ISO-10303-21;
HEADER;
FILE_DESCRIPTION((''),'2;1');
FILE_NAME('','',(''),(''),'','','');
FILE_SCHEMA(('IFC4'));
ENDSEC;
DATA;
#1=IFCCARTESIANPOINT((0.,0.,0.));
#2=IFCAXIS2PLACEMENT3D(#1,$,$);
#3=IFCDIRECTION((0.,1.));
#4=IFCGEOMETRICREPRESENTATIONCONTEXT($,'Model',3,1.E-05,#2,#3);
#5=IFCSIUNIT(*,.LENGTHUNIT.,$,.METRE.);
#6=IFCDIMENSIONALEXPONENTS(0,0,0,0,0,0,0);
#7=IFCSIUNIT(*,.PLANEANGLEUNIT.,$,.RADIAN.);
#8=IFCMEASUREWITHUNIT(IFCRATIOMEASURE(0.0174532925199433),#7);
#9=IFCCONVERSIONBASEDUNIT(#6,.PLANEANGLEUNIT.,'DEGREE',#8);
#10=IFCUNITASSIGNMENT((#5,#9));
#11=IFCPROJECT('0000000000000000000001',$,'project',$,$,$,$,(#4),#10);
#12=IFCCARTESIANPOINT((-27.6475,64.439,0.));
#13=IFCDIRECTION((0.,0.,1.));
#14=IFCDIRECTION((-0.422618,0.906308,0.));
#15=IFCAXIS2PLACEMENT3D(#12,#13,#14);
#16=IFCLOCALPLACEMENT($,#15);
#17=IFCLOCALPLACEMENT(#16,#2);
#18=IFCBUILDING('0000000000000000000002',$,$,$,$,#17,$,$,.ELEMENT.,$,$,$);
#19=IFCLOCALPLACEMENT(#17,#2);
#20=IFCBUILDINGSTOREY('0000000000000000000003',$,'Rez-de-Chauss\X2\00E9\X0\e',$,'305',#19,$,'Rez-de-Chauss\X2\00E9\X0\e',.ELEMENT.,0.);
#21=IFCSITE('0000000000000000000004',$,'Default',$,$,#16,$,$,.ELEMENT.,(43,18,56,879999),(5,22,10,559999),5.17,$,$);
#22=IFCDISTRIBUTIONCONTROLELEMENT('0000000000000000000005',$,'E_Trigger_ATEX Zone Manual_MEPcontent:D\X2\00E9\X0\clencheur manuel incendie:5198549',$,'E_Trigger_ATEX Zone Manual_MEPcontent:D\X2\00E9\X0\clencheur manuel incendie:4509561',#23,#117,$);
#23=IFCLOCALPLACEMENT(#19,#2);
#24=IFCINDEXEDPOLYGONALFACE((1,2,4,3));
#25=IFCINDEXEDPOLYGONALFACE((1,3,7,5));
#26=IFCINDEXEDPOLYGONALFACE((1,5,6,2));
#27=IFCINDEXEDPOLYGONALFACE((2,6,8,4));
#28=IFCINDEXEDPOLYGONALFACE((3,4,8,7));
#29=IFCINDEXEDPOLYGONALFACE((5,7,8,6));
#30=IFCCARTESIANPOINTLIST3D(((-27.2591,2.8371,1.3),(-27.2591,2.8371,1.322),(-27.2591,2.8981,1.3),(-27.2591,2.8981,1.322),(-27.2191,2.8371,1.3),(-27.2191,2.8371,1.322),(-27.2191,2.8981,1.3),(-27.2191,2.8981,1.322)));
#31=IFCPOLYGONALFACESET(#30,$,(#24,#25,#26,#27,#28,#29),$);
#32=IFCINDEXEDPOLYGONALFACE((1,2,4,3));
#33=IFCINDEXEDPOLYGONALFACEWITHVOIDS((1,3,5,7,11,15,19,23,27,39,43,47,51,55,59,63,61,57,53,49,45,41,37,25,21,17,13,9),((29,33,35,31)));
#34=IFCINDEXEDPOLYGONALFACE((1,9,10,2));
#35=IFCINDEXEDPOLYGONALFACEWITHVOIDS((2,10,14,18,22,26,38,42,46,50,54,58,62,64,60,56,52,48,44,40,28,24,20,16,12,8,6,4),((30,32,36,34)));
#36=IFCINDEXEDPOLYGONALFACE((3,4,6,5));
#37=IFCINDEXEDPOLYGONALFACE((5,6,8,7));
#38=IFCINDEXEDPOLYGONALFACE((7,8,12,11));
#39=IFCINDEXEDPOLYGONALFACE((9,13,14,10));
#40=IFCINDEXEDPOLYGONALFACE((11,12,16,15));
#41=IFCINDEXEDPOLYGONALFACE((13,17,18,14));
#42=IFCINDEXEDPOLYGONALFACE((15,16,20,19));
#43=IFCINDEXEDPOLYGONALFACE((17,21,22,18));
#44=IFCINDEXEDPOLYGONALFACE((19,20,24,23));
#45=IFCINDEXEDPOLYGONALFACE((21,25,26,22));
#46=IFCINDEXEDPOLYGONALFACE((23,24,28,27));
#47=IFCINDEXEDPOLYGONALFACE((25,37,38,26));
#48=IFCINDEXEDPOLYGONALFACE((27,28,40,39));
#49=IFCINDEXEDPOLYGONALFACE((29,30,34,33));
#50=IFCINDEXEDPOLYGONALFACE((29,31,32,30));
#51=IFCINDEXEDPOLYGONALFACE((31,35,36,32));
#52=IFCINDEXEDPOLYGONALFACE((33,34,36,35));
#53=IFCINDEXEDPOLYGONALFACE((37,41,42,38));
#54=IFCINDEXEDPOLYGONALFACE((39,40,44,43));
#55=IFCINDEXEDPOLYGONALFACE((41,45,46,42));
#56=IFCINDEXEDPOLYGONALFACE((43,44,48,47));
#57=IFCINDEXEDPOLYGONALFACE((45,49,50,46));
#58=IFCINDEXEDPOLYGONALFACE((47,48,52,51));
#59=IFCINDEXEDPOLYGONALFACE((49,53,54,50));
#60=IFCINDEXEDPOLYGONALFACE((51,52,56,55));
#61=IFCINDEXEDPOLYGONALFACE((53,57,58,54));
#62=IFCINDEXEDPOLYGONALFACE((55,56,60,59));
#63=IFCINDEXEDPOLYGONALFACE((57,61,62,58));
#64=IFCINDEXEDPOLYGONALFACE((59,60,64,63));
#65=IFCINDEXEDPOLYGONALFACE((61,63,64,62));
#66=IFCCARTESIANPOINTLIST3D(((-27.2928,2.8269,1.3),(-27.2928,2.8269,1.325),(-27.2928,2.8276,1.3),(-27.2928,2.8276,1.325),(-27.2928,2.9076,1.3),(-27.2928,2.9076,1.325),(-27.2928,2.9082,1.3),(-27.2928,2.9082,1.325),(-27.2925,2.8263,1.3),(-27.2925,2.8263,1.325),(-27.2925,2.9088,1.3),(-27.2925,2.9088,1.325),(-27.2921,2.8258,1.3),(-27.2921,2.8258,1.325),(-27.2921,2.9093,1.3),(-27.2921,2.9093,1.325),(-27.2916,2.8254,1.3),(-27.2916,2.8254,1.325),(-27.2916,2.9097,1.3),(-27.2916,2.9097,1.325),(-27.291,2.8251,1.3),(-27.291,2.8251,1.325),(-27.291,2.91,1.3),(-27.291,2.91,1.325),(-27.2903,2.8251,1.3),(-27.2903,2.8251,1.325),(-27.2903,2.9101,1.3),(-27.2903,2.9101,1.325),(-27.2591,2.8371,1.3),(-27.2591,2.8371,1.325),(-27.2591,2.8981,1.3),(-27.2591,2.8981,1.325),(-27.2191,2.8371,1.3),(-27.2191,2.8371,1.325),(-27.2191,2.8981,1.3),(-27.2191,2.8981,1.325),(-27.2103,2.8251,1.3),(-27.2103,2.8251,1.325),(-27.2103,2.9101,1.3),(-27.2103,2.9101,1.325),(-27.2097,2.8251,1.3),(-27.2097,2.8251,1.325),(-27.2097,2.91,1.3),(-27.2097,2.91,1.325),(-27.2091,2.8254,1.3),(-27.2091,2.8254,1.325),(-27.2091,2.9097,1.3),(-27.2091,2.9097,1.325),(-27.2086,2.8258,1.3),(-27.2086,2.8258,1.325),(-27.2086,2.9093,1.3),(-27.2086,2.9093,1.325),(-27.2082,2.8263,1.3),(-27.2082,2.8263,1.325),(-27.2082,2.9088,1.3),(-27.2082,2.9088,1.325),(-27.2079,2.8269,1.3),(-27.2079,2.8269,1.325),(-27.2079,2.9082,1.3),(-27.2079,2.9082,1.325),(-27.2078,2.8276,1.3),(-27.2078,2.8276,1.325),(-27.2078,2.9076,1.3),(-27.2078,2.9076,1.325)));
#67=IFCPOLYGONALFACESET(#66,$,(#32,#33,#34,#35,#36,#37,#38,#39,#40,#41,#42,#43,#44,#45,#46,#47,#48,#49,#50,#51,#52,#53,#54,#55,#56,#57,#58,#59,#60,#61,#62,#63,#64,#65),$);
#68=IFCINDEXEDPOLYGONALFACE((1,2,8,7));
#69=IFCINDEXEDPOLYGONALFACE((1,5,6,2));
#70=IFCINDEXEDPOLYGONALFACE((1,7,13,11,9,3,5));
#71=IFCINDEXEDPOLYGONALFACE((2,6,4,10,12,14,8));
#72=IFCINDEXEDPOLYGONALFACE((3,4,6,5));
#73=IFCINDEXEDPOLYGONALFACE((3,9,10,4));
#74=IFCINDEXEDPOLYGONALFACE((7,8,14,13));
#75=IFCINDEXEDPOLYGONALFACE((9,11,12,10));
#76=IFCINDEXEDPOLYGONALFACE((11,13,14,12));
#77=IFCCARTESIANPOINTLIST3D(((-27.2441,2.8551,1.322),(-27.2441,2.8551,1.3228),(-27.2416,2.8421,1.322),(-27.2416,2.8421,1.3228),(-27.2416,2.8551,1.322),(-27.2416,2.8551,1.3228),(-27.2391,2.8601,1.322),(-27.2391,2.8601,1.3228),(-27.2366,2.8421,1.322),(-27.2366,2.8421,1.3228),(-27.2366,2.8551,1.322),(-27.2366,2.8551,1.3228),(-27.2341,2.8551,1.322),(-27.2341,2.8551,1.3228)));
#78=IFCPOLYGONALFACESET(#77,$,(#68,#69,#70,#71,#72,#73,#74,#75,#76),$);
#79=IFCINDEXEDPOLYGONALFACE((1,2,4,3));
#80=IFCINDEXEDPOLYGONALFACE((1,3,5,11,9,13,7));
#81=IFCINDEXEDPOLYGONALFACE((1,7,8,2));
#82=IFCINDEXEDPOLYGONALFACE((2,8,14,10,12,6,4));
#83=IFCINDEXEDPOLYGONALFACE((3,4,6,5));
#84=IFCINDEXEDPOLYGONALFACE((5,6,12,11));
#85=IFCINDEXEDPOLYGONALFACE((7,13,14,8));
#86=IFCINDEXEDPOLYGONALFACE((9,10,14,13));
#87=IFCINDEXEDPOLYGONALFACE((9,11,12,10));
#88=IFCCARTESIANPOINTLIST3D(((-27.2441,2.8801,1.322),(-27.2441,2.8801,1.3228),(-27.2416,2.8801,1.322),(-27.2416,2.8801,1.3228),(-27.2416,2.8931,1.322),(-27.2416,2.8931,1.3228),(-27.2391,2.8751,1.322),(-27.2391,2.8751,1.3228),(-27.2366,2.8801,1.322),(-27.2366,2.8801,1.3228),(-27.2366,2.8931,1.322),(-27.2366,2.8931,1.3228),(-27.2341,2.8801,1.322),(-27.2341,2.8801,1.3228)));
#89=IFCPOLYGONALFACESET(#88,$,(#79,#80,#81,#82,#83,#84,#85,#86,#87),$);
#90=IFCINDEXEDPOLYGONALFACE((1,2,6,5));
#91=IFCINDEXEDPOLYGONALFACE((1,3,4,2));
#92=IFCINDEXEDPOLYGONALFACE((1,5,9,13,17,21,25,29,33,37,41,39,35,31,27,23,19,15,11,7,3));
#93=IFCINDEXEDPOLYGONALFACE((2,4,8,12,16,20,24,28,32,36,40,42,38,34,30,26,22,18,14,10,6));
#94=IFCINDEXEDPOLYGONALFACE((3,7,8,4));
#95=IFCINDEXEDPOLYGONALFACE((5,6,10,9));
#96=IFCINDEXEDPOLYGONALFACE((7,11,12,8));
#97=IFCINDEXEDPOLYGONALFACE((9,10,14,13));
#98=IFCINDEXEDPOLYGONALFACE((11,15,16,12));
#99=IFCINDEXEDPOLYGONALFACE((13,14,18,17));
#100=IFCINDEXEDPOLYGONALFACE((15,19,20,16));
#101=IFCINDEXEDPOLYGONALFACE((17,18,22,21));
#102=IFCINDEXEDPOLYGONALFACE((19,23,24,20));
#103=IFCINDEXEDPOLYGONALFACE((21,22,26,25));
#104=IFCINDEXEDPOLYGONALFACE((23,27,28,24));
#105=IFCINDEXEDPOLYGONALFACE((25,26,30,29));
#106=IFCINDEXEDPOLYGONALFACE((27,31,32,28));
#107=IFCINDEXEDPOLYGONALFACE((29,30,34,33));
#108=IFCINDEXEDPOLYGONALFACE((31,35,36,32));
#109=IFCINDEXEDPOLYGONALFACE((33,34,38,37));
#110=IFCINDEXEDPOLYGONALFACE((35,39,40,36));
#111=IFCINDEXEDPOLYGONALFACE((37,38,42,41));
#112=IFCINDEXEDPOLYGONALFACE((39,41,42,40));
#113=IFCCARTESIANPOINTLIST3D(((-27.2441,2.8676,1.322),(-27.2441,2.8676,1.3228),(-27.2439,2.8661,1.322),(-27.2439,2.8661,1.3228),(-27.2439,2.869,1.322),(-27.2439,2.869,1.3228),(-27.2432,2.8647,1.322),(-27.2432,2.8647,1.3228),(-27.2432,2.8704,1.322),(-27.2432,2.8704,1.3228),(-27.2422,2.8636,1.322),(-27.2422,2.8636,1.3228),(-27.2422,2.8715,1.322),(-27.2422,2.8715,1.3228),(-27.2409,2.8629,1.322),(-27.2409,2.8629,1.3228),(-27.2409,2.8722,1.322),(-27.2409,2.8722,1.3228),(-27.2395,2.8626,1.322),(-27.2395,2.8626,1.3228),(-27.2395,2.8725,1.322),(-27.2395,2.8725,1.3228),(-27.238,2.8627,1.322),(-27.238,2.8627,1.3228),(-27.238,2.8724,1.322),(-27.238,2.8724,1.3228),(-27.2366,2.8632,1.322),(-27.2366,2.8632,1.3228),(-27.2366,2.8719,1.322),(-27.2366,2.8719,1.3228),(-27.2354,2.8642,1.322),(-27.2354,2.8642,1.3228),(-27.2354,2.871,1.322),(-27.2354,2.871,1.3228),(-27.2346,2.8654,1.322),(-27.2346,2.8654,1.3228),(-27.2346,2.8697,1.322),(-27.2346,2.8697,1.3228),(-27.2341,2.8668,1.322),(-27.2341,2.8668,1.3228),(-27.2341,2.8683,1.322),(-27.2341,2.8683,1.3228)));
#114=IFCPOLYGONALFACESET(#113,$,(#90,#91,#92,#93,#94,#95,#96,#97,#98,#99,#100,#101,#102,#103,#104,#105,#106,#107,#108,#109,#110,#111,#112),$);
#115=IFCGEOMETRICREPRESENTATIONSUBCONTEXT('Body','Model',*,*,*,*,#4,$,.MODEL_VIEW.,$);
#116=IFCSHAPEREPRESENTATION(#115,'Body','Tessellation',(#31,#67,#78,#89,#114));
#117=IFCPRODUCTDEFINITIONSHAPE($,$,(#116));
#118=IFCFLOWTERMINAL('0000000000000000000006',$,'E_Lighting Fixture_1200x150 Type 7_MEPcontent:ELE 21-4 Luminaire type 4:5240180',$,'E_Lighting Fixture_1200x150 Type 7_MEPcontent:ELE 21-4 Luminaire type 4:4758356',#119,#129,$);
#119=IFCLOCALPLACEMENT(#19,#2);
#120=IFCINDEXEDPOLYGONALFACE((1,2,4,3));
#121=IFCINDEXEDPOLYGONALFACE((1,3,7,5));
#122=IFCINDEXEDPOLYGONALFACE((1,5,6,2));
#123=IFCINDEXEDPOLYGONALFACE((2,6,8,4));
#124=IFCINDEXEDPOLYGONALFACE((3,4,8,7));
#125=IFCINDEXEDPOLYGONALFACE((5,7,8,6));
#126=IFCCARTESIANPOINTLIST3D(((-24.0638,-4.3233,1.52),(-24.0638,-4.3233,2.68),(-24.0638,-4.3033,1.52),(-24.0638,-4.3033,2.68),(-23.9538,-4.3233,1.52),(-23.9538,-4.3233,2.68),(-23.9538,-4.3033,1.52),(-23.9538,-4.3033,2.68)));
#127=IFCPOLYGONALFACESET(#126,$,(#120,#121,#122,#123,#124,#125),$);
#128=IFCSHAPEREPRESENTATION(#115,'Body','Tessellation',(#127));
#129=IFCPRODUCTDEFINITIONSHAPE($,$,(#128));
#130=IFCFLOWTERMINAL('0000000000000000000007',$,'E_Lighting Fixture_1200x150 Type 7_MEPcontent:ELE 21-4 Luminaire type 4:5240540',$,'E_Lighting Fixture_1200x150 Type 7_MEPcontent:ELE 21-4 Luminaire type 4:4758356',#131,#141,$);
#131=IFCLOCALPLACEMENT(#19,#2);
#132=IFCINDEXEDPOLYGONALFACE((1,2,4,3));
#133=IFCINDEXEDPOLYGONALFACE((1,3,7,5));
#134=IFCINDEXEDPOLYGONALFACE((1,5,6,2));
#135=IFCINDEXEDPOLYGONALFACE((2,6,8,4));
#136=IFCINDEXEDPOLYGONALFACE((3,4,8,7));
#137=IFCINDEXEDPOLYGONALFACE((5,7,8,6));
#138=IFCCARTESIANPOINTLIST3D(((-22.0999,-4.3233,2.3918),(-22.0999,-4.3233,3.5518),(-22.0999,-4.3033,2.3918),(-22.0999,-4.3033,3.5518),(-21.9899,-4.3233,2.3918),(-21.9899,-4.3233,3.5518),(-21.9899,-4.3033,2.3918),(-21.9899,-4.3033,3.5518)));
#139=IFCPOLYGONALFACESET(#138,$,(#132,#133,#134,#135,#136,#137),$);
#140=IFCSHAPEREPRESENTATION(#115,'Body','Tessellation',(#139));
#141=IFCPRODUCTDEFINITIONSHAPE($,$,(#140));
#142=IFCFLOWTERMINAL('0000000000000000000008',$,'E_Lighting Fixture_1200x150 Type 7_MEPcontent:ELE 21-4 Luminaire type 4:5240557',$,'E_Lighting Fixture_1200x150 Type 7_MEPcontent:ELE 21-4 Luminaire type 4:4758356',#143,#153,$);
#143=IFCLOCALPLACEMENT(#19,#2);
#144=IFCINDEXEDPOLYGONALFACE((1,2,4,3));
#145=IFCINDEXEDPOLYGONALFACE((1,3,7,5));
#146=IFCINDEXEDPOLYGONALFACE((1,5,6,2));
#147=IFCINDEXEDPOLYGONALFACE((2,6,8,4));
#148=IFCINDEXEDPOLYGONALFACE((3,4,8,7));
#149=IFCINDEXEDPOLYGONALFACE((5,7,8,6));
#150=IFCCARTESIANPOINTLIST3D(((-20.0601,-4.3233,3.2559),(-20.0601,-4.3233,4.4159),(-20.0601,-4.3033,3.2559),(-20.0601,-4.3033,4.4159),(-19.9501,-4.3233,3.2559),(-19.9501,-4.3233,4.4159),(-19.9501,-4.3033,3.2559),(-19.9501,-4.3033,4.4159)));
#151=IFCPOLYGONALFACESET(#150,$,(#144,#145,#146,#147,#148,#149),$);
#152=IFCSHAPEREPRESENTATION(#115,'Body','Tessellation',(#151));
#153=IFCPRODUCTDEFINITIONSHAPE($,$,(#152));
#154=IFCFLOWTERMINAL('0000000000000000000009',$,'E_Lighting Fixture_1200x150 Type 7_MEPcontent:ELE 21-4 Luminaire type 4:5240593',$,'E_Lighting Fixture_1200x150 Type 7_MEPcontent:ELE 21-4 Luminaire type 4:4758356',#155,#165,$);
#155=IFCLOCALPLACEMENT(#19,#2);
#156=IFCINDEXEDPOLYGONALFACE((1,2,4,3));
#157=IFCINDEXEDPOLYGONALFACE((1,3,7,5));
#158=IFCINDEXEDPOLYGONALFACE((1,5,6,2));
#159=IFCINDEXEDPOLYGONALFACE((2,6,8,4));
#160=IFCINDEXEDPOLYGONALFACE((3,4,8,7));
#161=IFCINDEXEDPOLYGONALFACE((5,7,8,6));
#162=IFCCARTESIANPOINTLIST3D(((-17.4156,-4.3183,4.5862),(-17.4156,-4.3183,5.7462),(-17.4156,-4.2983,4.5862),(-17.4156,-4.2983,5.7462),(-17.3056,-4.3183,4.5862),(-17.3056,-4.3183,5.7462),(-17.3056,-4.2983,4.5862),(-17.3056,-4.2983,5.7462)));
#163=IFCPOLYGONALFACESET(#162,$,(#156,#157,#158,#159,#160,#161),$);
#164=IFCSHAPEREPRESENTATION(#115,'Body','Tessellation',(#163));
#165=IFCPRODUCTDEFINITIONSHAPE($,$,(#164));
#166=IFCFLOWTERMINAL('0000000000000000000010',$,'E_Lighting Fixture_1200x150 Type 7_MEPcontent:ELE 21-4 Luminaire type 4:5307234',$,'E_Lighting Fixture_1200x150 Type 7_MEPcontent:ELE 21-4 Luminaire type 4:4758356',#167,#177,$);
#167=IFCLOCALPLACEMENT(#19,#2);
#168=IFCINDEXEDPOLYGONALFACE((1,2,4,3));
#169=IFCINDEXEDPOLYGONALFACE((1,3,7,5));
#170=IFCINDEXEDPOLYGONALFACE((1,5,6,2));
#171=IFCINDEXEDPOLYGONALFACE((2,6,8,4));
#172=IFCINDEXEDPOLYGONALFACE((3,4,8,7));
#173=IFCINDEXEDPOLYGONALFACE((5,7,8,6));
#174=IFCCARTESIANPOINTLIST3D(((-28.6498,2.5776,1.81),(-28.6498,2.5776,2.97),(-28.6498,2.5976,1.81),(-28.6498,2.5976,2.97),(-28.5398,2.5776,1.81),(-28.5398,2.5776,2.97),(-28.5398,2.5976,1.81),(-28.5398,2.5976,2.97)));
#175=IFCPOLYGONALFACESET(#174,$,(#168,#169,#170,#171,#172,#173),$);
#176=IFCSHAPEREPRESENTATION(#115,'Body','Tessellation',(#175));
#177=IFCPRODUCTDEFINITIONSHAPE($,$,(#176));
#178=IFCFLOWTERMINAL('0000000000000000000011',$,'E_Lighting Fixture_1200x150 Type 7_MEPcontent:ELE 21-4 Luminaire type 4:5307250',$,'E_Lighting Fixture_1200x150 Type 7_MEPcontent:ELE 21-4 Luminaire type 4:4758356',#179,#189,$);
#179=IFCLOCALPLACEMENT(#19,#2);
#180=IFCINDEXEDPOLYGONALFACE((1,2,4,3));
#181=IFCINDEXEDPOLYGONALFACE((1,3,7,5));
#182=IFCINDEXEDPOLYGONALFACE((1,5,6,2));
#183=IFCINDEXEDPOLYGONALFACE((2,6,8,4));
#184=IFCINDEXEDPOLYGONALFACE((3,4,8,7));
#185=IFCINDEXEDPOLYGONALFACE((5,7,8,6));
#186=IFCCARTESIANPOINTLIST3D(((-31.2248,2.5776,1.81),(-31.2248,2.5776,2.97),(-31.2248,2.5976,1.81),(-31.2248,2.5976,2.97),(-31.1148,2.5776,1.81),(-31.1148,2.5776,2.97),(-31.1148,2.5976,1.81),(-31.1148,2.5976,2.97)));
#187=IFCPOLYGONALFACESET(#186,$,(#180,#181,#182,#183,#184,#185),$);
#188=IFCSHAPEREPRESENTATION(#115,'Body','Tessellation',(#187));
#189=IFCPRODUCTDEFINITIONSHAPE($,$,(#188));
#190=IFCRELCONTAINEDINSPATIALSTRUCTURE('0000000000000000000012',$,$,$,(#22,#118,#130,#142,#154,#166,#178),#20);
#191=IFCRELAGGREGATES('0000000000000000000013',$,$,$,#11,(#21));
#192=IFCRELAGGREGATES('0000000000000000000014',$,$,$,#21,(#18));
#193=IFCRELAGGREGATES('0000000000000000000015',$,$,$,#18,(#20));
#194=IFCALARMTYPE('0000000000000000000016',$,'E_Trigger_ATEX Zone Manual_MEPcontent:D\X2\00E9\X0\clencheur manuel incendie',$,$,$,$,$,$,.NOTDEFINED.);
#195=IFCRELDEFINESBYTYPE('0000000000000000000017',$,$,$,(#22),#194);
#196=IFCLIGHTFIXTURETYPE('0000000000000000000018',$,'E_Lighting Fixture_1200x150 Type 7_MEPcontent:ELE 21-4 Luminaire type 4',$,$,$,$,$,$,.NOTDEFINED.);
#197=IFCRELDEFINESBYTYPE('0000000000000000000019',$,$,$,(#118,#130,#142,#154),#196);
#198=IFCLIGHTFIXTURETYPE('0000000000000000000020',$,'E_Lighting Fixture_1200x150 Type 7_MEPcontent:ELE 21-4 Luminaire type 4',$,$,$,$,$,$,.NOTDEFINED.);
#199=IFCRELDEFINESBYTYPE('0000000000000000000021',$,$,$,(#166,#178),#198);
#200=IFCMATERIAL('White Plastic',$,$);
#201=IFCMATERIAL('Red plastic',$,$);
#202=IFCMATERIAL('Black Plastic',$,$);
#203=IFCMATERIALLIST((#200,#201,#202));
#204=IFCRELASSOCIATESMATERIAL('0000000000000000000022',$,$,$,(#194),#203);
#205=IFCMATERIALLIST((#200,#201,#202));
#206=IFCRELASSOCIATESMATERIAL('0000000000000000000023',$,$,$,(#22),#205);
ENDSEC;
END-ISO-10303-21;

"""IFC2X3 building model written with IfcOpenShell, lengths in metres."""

from ifc_helpers import new_model, entity, si_unit, converted_unit, direction, frame, frame_2d, origin, origin_2d_with_axis, place, context, subcontext, project, spatial, polyline, circle_curve, parameter, trimmed, segment, composite_curve, rectangle, circle, outline, extrude, source, transform, mapped, material, material_list, type_object, type_shapes, element, save


model = new_model("IFC2X3")

# Units and contexts
model_context = context("Model", 3, precision=1e-05, world=origin(), true_north=direction((0.0, 1.0)))
body_context = subcontext(model_context, "Body", "Model", "MODEL_VIEW")
ifc_project = project(units=[si_unit("LENGTHUNIT", "METRE"), converted_unit("PLANEANGLEUNIT", "DEGREE", entity("IfcRatioMeasure", 0.0174532925199433), si_unit("PLANEANGLEUNIT", "RADIAN"), dimensions=[0, 0, 0, 0, 0, 0, 0])], contexts=[model_context])

# Site, building, storey
site_placement = place(None, frame((-27.6475, 64.439, 0.0), z_axis=(0.0, 0.0, 1.0), x_axis=(-0.422618, 0.906308, 0.0)))
site = spatial("IfcSite", under=ifc_project, at=site_placement, Name="Default", CompositionType="ELEMENT", RefLatitude=(43, 18, 56, 879999), RefLongitude=(5, 22, 10, 559999), RefElevation=5.17)
building_placement = place(site_placement, origin())
building = spatial("IfcBuilding", under=site, at=building_placement, CompositionType="ELEMENT")
storey_placement = place(building_placement, origin())
storey = spatial("IfcBuildingStorey", under=building, at=storey_placement, Name="Rez-de-Chaussée", ObjectType="305", LongName="Rez-de-Chaussée", CompositionType="ELEMENT", Elevation=0.0)

# Shared definitions
ifc_material_1 = material(Name="White Plastic")
ifc_material_2 = material(Name="Red plastic")
ifc_material_3 = material(Name="Black Plastic")

# Distribution control element
ifc_material_list_1 = material_list([ifc_material_1, ifc_material_2, ifc_material_3])
ifc_material_list_2 = material_list([ifc_material_1, ifc_material_2, ifc_material_3])
alarm_type_1 = type_object("IfcAlarmType", Name="E_Trigger_ATEX Zone Manual_MEPcontent:Déclencheur manuel incendie", PredefinedType="NOTDEFINED", material=ifc_material_list_2)
shared_shape_1 = source(origin(), body_context, "Body", "SweptSolid", [
    extrude(rectangle(XDim=0.061, YDim=0.04, at=origin_2d_with_axis()), frame((0.0, 0.0112, 0.0)), (0.0, 0.0, 1.0), 0.022),
    extrude(outline(composite_curve([segment(polyline([(-0.04, -0.0425), (0.04, -0.0425)]), True, "CONTINUOUS"), segment(trimmed(circle_curve(frame_2d((0.04, -0.04), x_axis=(-1.0, 0.0)), 0.0025), [parameter(90.0)], [parameter(180.0)], True, "PARAMETER"), True, "CONTINUOUS"), segment(polyline([(0.0425, -0.04), (0.0425, 0.04)]), True, "CONTINUOUS"), segment(trimmed(circle_curve(frame_2d((0.04, 0.04), x_axis=(-1.0, 0.0)), 0.0025), [parameter(180.0)], [parameter(270.0)], True, "PARAMETER"), True, "CONTINUOUS"), segment(polyline([(0.04, 0.0425), (-0.04, 0.0425)]), True, "CONTINUOUS"), segment(trimmed(circle_curve(frame_2d((-0.04, 0.04), x_axis=(-1.0, 0.0)), 0.0025), [parameter(270.0)], [parameter(0.0)], True, "PARAMETER"), True, "CONTINUOUS"), segment(polyline([(-0.0425, 0.04), (-0.0425, -0.04)]), True, "CONTINUOUS"), segment(trimmed(circle_curve(frame_2d((-0.04, -0.04), x_axis=(-1.0, 0.0)), 0.0025), [parameter(360.0)], [parameter(90.0)], True, "PARAMETER"), True, "CONTINUOUS")], self_intersect=False), holes=[polyline([(-0.0305, -0.0088), (-0.0305, 0.0312), (0.0305, 0.0312), (0.0305, -0.0088), (-0.0305, -0.0088)])]), origin(), (0.0, 0.0, 1.0), 0.025),
    extrude(outline(polyline([(-0.01, 0.0025), (-0.01, -0.0025), (0.003, -0.0025), (0.003, -0.005), (0.008, 0.0), (0.003, 0.005), (0.003, 0.0025), (-0.01, 0.0025)])), frame((0.0155, 0.0112, 0.022), z_axis=(0.0, 0.0, -1.0), x_axis=(-1.0, 0.0, 0.0)), (0.0, 0.0, -1.0), 0.0008),
    extrude(outline(polyline([(-0.0014, -0.0057), (0.0057, -0.0057), (0.0057, 0.0014), (0.0039, -0.0004), (-0.0053, 0.0088), (-0.0088, 0.0053), (0.0004, -0.0039), (-0.0014, -0.0057)])), frame((-0.0155, 0.0112, 0.022), z_axis=(0.0, 0.0, 1.0), x_axis=(0.707107, 0.707107, 0.0)), (0.0, 0.0, 1.0), 0.0008),
    extrude(circle(Radius=0.005, at=frame_2d((0.0, 0.0), x_axis=(1.0, 0.0))), frame((0.0, 0.0112, 0.022), z_axis=(0.0, 0.0, 1.0), x_axis=(0.0, -1.0, 0.0)), (0.0, 0.0, 1.0), 0.0008),
])
type_shapes(alarm_type_1, [shared_shape_1])
distribution_control_element_1_placement = place(storey_placement, frame((-27.2503, 2.8676, 1.3), z_axis=(0.0, 0.0, 1.0), x_axis=(0.0, -1.0, 0.0)))
element("IfcDistributionControlElement", 1, at=distribution_control_element_1_placement, inside=storey, type_object=alarm_type_1, material=ifc_material_list_1, Name="E_Trigger_ATEX Zone Manual_MEPcontent:Déclencheur manuel incendie:5198549", ObjectType="E_Trigger_ATEX Zone Manual_MEPcontent:Déclencheur manuel incendie:4509561", context=body_context, shape_type="MappedRepresentation", body=[
    mapped(shared_shape_1, transform((0.0, 0.0, 0.0), scale=1.0)),
])

# Flow terminals
light_fixture_type_1 = type_object("IfcLightFixtureType", Name="E_Lighting Fixture_1200x150 Type 7_MEPcontent:ELE 21-4 Luminaire type 4", PredefinedType="NOTDEFINED")
shared_shape_2 = source(origin(), body_context, "Body", "SweptSolid", [
    extrude(rectangle(XDim=0.02, YDim=0.11, at=frame_2d((0.0, 0.0), x_axis=(1.0, 0.0))), frame((0.0, 0.01, -0.58), z_axis=(0.0, 0.0, 1.0), x_axis=(0.0, -1.0, 0.0)), (0.0, 0.0, 1.0), 1.16),
])
type_shapes(light_fixture_type_1, [shared_shape_2])
for number, where, name in (
    (2, (-24.0088, -4.3233, 2.1), "E_Lighting Fixture_1200x150 Type 7_MEPcontent:ELE 21-4 Luminaire type 4:5240180"),
    (3, (-22.0449, -4.3233, 2.9718), "E_Lighting Fixture_1200x150 Type 7_MEPcontent:ELE 21-4 Luminaire type 4:5240540"),
    (4, (-20.0051, -4.3233, 3.8359), "E_Lighting Fixture_1200x150 Type 7_MEPcontent:ELE 21-4 Luminaire type 4:5240557"),
    (5, (-17.3606, -4.3183, 5.1662), "E_Lighting Fixture_1200x150 Type 7_MEPcontent:ELE 21-4 Luminaire type 4:5240593"),
):
    element("IfcFlowTerminal", number, at=place(storey_placement, frame(where)), inside=storey, type_object=light_fixture_type_1, Name=name, ObjectType="E_Lighting Fixture_1200x150 Type 7_MEPcontent:ELE 21-4 Luminaire type 4:4758356", context=body_context, shape_type="MappedRepresentation", body=[
        mapped(shared_shape_2, transform((0.0, 0.0, 0.0), scale=1.0)),
    ])
light_fixture_type_2 = type_object("IfcLightFixtureType", Name="E_Lighting Fixture_1200x150 Type 7_MEPcontent:ELE 21-4 Luminaire type 4", PredefinedType="NOTDEFINED")
shared_shape_3 = source(origin(), body_context, "Body", "SweptSolid", [
    extrude(rectangle(XDim=0.02, YDim=0.11, at=frame_2d((0.0, 0.0), x_axis=(1.0, 0.0))), frame((-0.01, 0.0, -0.58)), (0.0, 0.0, 1.0), 1.16),
])
type_shapes(light_fixture_type_2, [shared_shape_3])
for number, where, z_axis, x_axis, name in (
    (6, (-28.5948, 2.5976, 2.39), (0.0, 0.0, 1.0), (0.0, 1.0, 0.0), "E_Lighting Fixture_1200x150 Type 7_MEPcontent:ELE 21-4 Luminaire type 4:5307234"),
    (7, (-31.1698, 2.5976, 2.39), (0.0, 0.0, 1.0), (0.0, 1.0, 0.0), "E_Lighting Fixture_1200x150 Type 7_MEPcontent:ELE 21-4 Luminaire type 4:5307250"),
):
    element("IfcFlowTerminal", number, at=place(storey_placement, frame(where, z_axis=z_axis, x_axis=x_axis)), inside=storey, type_object=light_fixture_type_2, Name=name, ObjectType="E_Lighting Fixture_1200x150 Type 7_MEPcontent:ELE 21-4 Luminaire type 4:4758356", context=body_context, shape_type="MappedRepresentation", body=[
        mapped(shared_shape_3, transform((0.0, 0.0, 0.0), scale=1.0)),
    ])

save(model, "model.ifc")
